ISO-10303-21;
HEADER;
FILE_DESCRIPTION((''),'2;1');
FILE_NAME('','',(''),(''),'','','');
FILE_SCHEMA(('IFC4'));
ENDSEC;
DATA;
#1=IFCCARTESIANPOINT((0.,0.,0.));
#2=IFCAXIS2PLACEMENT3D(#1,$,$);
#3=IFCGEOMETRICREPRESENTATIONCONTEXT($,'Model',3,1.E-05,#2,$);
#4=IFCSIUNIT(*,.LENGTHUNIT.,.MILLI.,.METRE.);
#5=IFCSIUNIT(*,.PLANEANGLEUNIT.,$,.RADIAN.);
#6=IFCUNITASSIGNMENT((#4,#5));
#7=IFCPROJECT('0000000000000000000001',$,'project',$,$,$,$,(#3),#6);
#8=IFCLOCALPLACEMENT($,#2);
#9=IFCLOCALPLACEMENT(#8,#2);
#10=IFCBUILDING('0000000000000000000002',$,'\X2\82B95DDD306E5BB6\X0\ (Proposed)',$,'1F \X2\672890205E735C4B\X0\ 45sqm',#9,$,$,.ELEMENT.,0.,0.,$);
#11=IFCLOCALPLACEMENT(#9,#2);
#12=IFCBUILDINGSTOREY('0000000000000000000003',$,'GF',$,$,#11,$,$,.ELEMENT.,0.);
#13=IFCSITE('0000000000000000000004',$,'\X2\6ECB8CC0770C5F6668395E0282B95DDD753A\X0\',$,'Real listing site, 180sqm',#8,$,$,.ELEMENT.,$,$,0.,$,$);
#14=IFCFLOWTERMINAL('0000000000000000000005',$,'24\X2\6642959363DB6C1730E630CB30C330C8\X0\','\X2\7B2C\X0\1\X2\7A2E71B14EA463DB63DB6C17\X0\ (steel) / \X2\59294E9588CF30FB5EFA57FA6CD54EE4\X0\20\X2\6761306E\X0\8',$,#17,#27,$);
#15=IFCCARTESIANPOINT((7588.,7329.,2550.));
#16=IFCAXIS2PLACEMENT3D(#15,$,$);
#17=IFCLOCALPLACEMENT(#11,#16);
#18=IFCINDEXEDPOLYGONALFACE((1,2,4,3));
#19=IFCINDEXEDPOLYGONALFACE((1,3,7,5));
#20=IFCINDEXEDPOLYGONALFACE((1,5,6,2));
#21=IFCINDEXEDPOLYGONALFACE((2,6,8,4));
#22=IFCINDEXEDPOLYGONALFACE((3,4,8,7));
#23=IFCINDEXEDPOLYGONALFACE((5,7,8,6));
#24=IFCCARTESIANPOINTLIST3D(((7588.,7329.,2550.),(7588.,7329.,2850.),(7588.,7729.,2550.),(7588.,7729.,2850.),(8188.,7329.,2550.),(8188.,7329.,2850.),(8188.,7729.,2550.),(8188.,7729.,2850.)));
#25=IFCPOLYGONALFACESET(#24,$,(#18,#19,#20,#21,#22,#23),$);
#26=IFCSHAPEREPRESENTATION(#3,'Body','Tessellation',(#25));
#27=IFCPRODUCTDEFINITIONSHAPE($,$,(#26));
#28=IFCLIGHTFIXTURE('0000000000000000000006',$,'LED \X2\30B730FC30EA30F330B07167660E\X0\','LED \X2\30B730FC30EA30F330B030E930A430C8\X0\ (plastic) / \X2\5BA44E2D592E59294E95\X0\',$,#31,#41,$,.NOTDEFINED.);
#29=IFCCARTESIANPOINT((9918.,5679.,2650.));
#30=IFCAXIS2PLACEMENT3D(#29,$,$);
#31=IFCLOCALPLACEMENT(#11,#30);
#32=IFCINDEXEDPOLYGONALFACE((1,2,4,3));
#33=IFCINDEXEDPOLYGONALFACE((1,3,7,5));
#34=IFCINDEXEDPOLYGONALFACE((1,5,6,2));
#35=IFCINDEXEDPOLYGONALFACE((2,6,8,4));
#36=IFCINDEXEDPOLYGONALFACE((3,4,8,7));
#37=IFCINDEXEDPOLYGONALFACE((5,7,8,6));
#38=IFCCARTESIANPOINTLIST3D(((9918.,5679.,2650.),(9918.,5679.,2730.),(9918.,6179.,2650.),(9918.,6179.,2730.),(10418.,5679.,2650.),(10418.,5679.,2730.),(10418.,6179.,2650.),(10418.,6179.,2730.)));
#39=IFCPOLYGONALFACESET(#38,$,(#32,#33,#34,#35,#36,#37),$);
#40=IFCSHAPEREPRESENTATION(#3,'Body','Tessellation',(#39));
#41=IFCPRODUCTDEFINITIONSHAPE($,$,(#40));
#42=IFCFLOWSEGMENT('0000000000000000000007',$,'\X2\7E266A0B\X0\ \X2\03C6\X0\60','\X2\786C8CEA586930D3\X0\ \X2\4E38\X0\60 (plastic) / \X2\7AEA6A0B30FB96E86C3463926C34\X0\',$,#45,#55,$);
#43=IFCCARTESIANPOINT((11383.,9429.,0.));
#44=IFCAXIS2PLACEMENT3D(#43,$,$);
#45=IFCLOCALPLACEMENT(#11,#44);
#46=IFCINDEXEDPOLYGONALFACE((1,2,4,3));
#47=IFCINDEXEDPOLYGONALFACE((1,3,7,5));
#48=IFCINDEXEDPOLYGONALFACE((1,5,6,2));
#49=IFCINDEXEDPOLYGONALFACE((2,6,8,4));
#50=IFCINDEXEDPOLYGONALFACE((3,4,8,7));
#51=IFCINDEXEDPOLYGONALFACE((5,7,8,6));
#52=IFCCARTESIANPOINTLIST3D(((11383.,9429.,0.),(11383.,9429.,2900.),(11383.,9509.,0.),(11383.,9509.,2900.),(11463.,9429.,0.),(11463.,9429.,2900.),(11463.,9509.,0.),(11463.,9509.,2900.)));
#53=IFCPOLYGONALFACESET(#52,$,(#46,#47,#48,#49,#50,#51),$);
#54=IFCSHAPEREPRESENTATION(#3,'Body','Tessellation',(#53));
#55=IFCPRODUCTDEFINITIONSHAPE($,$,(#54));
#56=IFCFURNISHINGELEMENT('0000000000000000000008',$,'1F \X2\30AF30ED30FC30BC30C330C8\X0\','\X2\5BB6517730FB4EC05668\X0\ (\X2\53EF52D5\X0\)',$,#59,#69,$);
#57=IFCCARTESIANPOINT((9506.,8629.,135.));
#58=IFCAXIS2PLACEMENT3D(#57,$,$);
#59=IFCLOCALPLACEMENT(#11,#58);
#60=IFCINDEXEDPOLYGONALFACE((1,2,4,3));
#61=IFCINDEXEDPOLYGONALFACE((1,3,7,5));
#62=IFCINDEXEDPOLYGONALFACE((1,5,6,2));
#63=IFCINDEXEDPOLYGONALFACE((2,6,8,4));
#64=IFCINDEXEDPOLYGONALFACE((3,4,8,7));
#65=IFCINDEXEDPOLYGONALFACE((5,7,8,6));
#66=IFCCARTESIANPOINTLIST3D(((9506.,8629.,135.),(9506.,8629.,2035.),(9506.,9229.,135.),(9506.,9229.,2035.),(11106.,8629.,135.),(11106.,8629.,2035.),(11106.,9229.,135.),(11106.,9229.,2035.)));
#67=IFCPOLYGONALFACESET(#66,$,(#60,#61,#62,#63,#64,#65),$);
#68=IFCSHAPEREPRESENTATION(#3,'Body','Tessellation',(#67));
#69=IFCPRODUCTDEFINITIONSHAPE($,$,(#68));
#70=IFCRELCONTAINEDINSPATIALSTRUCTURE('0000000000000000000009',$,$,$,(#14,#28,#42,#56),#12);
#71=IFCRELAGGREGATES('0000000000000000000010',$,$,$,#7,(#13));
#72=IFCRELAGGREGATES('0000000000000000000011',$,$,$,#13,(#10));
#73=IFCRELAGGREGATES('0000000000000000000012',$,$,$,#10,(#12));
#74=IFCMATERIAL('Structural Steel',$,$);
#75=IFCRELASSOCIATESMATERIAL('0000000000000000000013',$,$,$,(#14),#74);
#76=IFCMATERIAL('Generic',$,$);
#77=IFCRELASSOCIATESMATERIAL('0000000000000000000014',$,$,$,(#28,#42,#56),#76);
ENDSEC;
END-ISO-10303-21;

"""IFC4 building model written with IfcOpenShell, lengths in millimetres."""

from ifc_helpers import new_model, si_unit, frame, frame_2d, origin, place, context, project, spatial, rectangle, extrude, material, element, save


model = new_model("IFC4")

# Units and contexts
model_context = context("Model", 3, precision=1e-05, world=origin())
ifc_project = project(units=[si_unit("LENGTHUNIT", "METRE", prefix="MILLI"), si_unit("PLANEANGLEUNIT", "RADIAN")], contexts=[model_context])

# Site, building, storey
site_placement = place(None, origin())
site = spatial("IfcSite", under=ifc_project, at=site_placement, Name="滋賀県彦根市芹川町", ObjectType="Real listing site, 180sqm", CompositionType="ELEMENT", RefElevation=0.0)
building_placement = place(site_placement, origin())
building = spatial("IfcBuilding", under=site, at=building_placement, Name="芹川の家 (Proposed)", ObjectType="1F 木造平屋 45sqm", CompositionType="ELEMENT", ElevationOfRefHeight=0.0, ElevationOfTerrain=0.0)
storey_placement = place(building_placement, origin())
storey = spatial("IfcBuildingStorey", under=building, at=storey_placement, Name="GF", CompositionType="ELEMENT", Elevation=0.0)

# Shared definitions
ifc_material_1 = material(Name="Generic")

# Flow terminal
ifc_material_2 = material(Name="Structural Steel")
flow_terminal_placement = place(storey_placement, frame((7588.0, 7329.0, 2550.0)))
element("IfcFlowTerminal", 1, at=flow_terminal_placement, inside=storey, material=ifc_material_2, Name="24時間換気ユニット", Description="第1種熱交換換気 (steel) / 天井裏・建基法令20条の8", context=model_context, shape_type="SweptSolid", body=[
    extrude(rectangle(XDim=600.0, YDim=400.0, at=frame_2d((300.0, 200.0))), frame((7588.0, 7329.0, 2550.0)), (0.0, 0.0, 1.0), 300.0),
])

# Light fixture
light_fixture_placement = place(storey_placement, frame((9918.0, 5679.0, 2650.0)))
element("IfcLightFixture", 2, at=light_fixture_placement, inside=storey, material=ifc_material_1, Name="LED シーリング照明", Description="LED シーリングライト (plastic) / 室中央天井", PredefinedType="NOTDEFINED", context=model_context, shape_type="SweptSolid", body=[
    extrude(rectangle(XDim=500.0, YDim=500.0, at=frame_2d((250.0, 250.0))), frame((9918.0, 5679.0, 2650.0)), (0.0, 0.0, 1.0), 80.0),
])

# Flow segment
flow_segment_placement = place(storey_placement, frame((11383.0, 9429.0, 0.0)))
element("IfcFlowSegment", 3, at=flow_segment_placement, inside=storey, material=ifc_material_1, Name="縦樋 φ60", Description="硬質塩ビ 丸60 (plastic) / 竪樋・雨水排水", context=model_context, shape_type="SweptSolid", body=[
    extrude(rectangle(XDim=80.0, YDim=80.0, at=frame_2d((40.0, 40.0))), frame((11383.0, 9429.0, 0.0)), (0.0, 0.0, 1.0), 2900.0),
])

# Furnishing element
furnishing_placement = place(storey_placement, frame((9506.0, 8629.0, 135.0)))
element("IfcFurnishingElement", 4, at=furnishing_placement, inside=storey, material=ifc_material_1, Name="1F クローゼット", Description="家具・什器 (可動)", context=model_context, shape_type="SweptSolid", body=[
    extrude(rectangle(XDim=1600.0, YDim=600.0, at=frame_2d((800.0, 300.0))), frame((9506.0, 8629.0, 135.0)), (0.0, 0.0, 1.0), 1900.0),
])

save(model, "model.ifc")
